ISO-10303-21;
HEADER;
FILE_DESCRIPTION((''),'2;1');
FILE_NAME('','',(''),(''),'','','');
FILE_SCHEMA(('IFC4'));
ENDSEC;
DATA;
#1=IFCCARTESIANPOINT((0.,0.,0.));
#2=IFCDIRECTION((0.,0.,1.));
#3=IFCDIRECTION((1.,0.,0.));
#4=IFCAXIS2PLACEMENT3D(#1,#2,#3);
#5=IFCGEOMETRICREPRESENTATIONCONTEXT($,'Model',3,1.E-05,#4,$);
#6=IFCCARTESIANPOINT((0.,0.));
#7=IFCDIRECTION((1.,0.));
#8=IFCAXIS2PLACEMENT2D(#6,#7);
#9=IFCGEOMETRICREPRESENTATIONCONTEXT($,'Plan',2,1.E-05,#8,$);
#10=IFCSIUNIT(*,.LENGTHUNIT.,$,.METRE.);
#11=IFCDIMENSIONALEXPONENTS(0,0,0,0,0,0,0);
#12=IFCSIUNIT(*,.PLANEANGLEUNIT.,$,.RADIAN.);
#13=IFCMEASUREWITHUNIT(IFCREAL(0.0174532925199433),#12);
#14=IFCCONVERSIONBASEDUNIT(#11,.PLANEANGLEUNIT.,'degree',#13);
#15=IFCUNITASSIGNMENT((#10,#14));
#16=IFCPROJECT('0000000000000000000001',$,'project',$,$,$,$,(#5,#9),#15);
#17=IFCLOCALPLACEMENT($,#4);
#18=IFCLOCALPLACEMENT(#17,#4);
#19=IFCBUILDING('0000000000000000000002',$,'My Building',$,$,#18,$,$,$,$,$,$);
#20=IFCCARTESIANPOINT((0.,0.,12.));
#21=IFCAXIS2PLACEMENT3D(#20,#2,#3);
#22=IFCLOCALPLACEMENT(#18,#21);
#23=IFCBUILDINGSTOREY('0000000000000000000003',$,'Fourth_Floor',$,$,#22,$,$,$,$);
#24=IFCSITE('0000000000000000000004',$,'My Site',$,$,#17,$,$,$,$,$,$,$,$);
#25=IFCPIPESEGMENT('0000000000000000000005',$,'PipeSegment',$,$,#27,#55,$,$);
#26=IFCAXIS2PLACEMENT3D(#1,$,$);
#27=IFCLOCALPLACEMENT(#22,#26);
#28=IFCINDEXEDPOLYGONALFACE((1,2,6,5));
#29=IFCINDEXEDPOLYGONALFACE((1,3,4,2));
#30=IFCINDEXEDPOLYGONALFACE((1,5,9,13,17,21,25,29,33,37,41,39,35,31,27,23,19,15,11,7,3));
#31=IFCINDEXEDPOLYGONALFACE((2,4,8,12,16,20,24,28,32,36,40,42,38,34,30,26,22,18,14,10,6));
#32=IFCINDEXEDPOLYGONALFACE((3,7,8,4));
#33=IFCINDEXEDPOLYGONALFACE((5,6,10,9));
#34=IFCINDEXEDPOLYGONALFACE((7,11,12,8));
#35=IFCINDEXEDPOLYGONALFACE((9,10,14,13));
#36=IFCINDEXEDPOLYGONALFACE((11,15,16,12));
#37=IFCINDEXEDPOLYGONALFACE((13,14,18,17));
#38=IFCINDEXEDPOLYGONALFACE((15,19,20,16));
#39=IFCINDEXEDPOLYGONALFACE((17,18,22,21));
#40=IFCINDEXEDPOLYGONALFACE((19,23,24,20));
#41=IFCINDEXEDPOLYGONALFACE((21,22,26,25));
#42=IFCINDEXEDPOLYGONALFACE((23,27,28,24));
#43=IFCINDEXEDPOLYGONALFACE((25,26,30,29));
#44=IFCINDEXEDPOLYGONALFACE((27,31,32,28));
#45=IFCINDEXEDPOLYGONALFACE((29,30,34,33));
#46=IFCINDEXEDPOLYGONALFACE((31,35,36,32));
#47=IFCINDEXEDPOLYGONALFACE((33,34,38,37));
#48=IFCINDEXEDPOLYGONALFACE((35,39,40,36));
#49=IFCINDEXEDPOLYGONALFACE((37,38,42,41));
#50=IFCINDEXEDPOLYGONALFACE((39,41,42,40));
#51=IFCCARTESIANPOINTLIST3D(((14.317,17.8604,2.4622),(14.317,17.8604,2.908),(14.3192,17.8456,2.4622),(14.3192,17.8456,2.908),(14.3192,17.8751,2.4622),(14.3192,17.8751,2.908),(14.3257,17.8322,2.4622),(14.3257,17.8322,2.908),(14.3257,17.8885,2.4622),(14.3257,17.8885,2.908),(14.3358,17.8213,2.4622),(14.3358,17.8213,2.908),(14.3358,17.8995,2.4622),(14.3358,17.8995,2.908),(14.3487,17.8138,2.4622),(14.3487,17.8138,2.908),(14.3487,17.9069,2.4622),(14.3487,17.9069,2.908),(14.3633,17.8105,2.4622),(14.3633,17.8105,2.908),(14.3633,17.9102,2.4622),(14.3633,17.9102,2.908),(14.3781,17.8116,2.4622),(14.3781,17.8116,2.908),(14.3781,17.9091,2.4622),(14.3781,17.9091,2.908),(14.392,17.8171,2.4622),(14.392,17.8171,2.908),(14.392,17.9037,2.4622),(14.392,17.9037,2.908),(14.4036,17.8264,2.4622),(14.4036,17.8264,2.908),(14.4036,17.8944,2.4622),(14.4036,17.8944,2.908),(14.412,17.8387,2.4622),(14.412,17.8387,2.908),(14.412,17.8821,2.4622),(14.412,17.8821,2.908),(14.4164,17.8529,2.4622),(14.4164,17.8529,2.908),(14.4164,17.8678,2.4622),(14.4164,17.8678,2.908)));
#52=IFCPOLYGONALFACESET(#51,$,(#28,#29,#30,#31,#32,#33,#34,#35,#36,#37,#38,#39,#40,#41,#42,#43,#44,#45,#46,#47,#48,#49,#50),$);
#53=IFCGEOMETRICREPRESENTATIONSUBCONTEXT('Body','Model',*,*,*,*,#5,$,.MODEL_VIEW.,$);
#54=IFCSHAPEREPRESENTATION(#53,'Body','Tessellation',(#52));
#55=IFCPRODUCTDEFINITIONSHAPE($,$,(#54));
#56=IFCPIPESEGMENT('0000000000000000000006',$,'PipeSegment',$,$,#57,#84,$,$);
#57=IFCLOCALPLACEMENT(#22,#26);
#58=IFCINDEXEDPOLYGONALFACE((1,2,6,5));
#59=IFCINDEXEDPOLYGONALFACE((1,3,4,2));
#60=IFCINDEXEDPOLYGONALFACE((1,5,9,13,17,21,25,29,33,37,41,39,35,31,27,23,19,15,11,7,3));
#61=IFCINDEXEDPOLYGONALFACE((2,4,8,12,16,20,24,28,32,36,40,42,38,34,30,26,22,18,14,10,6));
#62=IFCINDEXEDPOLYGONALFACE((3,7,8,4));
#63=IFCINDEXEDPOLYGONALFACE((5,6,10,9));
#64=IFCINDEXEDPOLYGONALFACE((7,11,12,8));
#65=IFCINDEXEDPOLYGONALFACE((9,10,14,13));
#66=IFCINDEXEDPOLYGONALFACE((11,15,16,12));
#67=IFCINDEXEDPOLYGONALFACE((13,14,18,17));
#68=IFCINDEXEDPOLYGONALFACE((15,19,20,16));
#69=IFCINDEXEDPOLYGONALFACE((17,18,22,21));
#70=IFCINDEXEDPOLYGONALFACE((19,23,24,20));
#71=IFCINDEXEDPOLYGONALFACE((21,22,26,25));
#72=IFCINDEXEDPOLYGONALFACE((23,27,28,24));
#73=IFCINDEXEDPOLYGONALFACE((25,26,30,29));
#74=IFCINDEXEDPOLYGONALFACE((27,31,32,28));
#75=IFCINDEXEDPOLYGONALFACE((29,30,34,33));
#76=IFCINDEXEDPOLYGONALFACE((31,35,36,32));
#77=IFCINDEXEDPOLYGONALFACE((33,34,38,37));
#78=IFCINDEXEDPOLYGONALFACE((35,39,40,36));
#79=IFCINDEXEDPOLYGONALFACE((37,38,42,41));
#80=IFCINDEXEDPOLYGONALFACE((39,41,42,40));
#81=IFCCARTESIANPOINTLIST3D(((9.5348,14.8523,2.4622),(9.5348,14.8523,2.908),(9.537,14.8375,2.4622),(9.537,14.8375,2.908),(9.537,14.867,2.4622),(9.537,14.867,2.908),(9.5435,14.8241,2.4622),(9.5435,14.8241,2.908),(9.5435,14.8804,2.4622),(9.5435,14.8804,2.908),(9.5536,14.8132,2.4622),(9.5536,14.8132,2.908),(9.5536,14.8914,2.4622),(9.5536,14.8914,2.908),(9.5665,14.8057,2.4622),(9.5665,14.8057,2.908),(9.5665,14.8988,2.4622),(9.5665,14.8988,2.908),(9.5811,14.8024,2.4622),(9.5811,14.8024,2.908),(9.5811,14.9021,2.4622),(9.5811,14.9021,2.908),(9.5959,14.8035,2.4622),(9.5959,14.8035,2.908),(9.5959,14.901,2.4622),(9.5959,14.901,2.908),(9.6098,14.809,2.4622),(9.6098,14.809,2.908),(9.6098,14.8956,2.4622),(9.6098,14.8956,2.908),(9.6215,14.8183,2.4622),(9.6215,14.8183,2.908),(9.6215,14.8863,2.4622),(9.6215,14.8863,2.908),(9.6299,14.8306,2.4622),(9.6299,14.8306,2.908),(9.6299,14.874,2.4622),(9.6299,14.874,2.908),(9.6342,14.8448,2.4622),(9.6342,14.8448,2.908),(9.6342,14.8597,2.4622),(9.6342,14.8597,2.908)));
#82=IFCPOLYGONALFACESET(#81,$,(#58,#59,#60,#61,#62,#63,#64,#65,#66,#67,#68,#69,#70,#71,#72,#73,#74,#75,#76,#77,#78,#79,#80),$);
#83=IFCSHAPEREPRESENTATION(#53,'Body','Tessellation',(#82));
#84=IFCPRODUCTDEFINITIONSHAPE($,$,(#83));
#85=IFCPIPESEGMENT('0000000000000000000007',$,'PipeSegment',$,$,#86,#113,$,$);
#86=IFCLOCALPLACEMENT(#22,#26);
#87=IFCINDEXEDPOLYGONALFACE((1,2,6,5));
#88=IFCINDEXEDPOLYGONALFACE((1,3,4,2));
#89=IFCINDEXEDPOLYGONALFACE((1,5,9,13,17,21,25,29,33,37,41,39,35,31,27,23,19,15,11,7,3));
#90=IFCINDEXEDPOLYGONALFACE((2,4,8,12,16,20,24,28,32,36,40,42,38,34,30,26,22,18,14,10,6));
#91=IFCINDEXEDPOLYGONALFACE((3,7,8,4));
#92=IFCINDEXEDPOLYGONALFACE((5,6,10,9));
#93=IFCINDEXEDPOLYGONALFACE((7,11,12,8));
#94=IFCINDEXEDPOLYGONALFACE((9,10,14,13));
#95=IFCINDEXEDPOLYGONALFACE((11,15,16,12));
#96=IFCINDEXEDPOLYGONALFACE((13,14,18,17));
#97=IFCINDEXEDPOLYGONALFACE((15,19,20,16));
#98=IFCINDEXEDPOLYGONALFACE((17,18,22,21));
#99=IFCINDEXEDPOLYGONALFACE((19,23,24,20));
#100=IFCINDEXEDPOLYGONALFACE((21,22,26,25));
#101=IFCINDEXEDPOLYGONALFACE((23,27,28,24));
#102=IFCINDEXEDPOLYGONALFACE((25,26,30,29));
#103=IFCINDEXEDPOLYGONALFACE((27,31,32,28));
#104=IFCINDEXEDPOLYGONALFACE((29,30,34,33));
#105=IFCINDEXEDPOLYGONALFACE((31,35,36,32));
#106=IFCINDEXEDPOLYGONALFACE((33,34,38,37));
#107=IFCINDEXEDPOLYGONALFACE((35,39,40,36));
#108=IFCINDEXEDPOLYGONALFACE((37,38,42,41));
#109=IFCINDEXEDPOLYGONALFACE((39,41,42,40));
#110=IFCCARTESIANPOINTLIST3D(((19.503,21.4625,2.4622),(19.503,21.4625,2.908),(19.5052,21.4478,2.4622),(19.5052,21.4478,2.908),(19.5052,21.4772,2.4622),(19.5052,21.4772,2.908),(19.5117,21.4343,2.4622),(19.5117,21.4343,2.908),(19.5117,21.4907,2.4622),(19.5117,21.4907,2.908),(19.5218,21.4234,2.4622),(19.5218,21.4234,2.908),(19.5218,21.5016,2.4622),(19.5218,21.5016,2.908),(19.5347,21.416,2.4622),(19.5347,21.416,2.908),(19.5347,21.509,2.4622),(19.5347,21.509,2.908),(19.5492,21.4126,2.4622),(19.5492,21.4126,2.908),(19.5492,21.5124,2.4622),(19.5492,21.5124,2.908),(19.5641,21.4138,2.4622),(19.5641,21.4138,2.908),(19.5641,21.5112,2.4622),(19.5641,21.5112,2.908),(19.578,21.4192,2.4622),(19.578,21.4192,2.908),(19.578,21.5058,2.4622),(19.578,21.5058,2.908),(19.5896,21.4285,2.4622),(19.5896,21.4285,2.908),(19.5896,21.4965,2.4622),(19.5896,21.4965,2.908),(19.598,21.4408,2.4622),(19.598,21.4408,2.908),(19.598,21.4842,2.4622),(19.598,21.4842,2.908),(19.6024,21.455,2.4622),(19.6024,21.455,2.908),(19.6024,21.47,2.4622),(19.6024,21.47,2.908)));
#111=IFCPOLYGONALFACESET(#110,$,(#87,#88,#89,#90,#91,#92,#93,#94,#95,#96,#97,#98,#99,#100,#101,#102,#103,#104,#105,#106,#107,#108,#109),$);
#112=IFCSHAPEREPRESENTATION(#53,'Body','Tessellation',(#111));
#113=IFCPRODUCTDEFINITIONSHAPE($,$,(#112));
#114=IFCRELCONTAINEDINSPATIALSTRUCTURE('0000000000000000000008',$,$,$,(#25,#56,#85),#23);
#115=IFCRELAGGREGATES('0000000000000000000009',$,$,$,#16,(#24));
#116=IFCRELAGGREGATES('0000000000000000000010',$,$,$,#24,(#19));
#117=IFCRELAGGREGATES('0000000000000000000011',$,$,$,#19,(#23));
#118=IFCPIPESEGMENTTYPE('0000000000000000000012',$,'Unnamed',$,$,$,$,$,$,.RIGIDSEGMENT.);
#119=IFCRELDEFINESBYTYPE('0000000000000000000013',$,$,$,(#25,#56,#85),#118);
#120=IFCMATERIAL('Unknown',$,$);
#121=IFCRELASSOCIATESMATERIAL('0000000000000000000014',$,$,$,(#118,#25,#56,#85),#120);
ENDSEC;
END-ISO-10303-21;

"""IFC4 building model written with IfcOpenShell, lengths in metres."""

from ifc_helpers import new_model, entity, si_unit, converted_unit, frame, origin_with_axes, origin_2d_with_axis, place, context, subcontext, project, spatial, circle, extrude, material, material_profile, profile_set, profile_usage, type_object, element, save


model = new_model("IFC4")

# Units and contexts
model_context = context("Model", 3, precision=1e-05, world=origin_with_axes())
plan_context = context("Plan", 2, precision=1e-05, world=origin_2d_with_axis())
body_context = subcontext(model_context, "Body", "Model", "MODEL_VIEW")
ifc_project = project(units=[si_unit("LENGTHUNIT", "METRE"), converted_unit("PLANEANGLEUNIT", "degree", entity("IfcReal", 0.0174532925199433), si_unit("PLANEANGLEUNIT", "RADIAN"), dimensions=[0, 0, 0, 0, 0, 0, 0])], contexts=[model_context, plan_context])

# Site, building, storey
site_placement = place(None, origin_with_axes())
site = spatial("IfcSite", under=ifc_project, at=site_placement, Name="My Site")
building_placement = place(site_placement, origin_with_axes())
building = spatial("IfcBuilding", under=site, at=building_placement, Name="My Building")
storey_placement = place(building_placement, frame((0.0, 0.0, 12.0), z_axis=(0.0, 0.0, 1.0), x_axis=(1.0, 0.0, 0.0)))
storey = spatial("IfcBuildingStorey", under=building, at=storey_placement, Name="Fourth_Floor")

# Shared definitions
ifc_material = material(Name="Unknown")

# Pipe segments
ifc_material_profile_1 = material_profile(ifc_material, circle(Radius=0.05))
ifc_profile_set_1 = profile_set([ifc_material_profile_1])
pipe_segment_type = type_object("IfcPipeSegmentType", Name="Unnamed", PredefinedType="RIGIDSEGMENT", material=ifc_profile_set_1)
ifc_profile_usage_1 = profile_usage(ifc_profile_set_1, cardinal=5)
pipe_segment_1_placement = place(storey_placement, frame((14.367, 17.8604, 2.908), z_axis=(0.0, 0.0, -1.0), x_axis=(-1.0, 0.0, 0.0)))
element("IfcPipeSegment", 1, at=pipe_segment_1_placement, inside=storey, type_object=pipe_segment_type, material=ifc_profile_usage_1, Name="PipeSegment", context=body_context, shape_type="SweptSolid", body=[
    extrude(circle(Radius=0.05), origin_with_axes(), (0.0, 0.0, 1.0), 0.4458),
])
ifc_profile_usage_2 = profile_usage(ifc_profile_set_1, cardinal=5)
pipe_segment_2_placement = place(storey_placement, frame((9.5848, 14.8523, 2.908), z_axis=(0.0, 0.0, -1.0), x_axis=(-1.0, 0.0, 0.0)))
element("IfcPipeSegment", 2, at=pipe_segment_2_placement, inside=storey, type_object=pipe_segment_type, material=ifc_profile_usage_2, Name="PipeSegment", context=body_context, shape_type="SweptSolid", body=[
    extrude(circle(Radius=0.05), origin_with_axes(), (0.0, 0.0, 1.0), 0.4458),
])
ifc_profile_usage_3 = profile_usage(ifc_profile_set_1, cardinal=5)
pipe_segment_3_placement = place(storey_placement, frame((19.553, 21.4625, 2.908), z_axis=(0.0, 0.0, -1.0), x_axis=(-1.0, 0.0, 0.0)))
element("IfcPipeSegment", 3, at=pipe_segment_3_placement, inside=storey, type_object=pipe_segment_type, material=ifc_profile_usage_3, Name="PipeSegment", context=body_context, shape_type="SweptSolid", body=[
    extrude(circle(Radius=0.05), origin_with_axes(), (0.0, 0.0, 1.0), 0.4458),
])

save(model, "model.ifc")
